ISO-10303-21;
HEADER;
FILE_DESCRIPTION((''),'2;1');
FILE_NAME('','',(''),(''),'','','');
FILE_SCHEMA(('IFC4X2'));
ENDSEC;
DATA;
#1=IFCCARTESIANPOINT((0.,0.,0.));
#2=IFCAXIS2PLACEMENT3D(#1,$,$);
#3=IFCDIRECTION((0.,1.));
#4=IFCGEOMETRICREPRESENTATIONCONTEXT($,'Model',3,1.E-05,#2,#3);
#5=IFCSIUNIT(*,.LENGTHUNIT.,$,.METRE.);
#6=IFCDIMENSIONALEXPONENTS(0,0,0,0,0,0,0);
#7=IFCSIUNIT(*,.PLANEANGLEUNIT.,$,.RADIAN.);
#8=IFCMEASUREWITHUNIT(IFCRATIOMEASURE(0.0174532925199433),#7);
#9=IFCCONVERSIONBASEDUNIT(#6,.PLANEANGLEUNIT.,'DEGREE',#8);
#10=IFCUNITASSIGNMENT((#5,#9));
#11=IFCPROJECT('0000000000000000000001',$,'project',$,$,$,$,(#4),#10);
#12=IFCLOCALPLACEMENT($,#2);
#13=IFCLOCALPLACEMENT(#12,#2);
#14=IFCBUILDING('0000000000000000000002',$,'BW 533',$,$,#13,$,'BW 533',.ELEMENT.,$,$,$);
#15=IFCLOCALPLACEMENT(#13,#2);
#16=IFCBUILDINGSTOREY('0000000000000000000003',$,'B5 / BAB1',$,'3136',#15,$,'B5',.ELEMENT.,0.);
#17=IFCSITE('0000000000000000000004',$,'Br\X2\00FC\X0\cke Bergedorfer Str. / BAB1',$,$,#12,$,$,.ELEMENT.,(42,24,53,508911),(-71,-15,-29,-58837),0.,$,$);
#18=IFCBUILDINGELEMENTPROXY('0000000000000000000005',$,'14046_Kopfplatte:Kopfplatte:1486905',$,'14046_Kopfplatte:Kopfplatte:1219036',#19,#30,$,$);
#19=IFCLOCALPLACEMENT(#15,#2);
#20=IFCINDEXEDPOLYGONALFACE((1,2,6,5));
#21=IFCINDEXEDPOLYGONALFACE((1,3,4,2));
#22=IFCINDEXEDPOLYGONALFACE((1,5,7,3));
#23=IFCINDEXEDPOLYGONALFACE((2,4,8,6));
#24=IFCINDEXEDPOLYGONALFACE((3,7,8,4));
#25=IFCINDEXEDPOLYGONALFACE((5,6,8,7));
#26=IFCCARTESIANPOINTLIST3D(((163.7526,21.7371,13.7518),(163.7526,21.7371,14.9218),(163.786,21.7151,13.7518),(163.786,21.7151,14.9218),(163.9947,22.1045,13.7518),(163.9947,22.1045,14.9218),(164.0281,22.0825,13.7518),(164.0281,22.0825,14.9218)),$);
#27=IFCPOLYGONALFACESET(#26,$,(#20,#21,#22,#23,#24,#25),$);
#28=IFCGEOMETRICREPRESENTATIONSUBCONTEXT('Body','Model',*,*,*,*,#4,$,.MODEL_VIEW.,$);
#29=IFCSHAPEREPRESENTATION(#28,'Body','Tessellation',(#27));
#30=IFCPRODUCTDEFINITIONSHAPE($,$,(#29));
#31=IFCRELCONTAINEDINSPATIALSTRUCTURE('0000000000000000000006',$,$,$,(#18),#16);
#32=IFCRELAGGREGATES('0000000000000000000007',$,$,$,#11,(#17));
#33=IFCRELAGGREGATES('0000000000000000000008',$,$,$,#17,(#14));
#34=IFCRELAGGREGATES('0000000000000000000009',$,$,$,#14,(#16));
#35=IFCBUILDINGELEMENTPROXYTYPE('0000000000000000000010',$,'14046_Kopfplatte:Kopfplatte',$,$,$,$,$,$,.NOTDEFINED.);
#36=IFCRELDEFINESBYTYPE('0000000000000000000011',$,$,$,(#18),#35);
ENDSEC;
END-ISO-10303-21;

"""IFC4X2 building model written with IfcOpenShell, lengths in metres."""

from ifc_helpers import new_model, entity, si_unit, converted_unit, direction, frame, frame_2d, origin, place, context, subcontext, project, spatial, rectangle, extrude, source, transform, mapped, type_object, type_shapes, element, save


model = new_model("IFC4X2")

# Units and contexts
model_context = context("Model", 3, precision=1e-05, world=origin(), true_north=direction((0.0, 1.0)))
body_context = subcontext(model_context, "Body", "Model", "MODEL_VIEW")
ifc_project = project(units=[si_unit("LENGTHUNIT", "METRE"), converted_unit("PLANEANGLEUNIT", "DEGREE", entity("IfcRatioMeasure", 0.0174532925199433), si_unit("PLANEANGLEUNIT", "RADIAN"), dimensions=[0, 0, 0, 0, 0, 0, 0])], contexts=[model_context])

# Site, building, storey
site_placement = place(None, origin())
site = spatial("IfcSite", under=ifc_project, at=site_placement, Name="Brücke Bergedorfer Str. / BAB1", CompositionType="ELEMENT", RefLatitude=(42, 24, 53, 508911), RefLongitude=(-71, -15, -29, -58837), RefElevation=0.0)
building_placement = place(site_placement, origin())
building = spatial("IfcBuilding", under=site, at=building_placement, Name="BW 533", LongName="BW 533", CompositionType="ELEMENT")
storey_placement = place(building_placement, origin())
storey = spatial("IfcBuildingStorey", under=building, at=storey_placement, Name="B5 / BAB1", ObjectType="3136", LongName="B5", CompositionType="ELEMENT", Elevation=0.0)

# Building element proxy
building_element_proxy_type_1 = type_object("IfcBuildingElementProxyType", Name="14046_Kopfplatte:Kopfplatte", PredefinedType="NOTDEFINED")
shared_shape_1 = source(origin(), body_context, "Body", "SweptSolid", [
    extrude(rectangle(XDim=0.04, YDim=0.44, at=frame_2d((0.0, 0.0), x_axis=(1.0, 0.0))), frame((163.8904, 21.9098, 13.7518), z_axis=(0.0, 0.0, 1.0), x_axis=(-0.835088, 0.550116, 0.0)), (0.0, 0.0, 1.0), 1.17),
])
type_shapes(building_element_proxy_type_1, [shared_shape_1])
proxy_1_placement = place(storey_placement, origin())
element("IfcBuildingElementProxy", 1, at=proxy_1_placement, inside=storey, type_object=building_element_proxy_type_1, Name="14046_Kopfplatte:Kopfplatte:1486905", ObjectType="14046_Kopfplatte:Kopfplatte:1219036", context=body_context, shape_type="MappedRepresentation", body=[
    mapped(shared_shape_1, transform((0.0, 0.0, 0.0), scale=1.0)),
])

save(model, "model.ifc")
